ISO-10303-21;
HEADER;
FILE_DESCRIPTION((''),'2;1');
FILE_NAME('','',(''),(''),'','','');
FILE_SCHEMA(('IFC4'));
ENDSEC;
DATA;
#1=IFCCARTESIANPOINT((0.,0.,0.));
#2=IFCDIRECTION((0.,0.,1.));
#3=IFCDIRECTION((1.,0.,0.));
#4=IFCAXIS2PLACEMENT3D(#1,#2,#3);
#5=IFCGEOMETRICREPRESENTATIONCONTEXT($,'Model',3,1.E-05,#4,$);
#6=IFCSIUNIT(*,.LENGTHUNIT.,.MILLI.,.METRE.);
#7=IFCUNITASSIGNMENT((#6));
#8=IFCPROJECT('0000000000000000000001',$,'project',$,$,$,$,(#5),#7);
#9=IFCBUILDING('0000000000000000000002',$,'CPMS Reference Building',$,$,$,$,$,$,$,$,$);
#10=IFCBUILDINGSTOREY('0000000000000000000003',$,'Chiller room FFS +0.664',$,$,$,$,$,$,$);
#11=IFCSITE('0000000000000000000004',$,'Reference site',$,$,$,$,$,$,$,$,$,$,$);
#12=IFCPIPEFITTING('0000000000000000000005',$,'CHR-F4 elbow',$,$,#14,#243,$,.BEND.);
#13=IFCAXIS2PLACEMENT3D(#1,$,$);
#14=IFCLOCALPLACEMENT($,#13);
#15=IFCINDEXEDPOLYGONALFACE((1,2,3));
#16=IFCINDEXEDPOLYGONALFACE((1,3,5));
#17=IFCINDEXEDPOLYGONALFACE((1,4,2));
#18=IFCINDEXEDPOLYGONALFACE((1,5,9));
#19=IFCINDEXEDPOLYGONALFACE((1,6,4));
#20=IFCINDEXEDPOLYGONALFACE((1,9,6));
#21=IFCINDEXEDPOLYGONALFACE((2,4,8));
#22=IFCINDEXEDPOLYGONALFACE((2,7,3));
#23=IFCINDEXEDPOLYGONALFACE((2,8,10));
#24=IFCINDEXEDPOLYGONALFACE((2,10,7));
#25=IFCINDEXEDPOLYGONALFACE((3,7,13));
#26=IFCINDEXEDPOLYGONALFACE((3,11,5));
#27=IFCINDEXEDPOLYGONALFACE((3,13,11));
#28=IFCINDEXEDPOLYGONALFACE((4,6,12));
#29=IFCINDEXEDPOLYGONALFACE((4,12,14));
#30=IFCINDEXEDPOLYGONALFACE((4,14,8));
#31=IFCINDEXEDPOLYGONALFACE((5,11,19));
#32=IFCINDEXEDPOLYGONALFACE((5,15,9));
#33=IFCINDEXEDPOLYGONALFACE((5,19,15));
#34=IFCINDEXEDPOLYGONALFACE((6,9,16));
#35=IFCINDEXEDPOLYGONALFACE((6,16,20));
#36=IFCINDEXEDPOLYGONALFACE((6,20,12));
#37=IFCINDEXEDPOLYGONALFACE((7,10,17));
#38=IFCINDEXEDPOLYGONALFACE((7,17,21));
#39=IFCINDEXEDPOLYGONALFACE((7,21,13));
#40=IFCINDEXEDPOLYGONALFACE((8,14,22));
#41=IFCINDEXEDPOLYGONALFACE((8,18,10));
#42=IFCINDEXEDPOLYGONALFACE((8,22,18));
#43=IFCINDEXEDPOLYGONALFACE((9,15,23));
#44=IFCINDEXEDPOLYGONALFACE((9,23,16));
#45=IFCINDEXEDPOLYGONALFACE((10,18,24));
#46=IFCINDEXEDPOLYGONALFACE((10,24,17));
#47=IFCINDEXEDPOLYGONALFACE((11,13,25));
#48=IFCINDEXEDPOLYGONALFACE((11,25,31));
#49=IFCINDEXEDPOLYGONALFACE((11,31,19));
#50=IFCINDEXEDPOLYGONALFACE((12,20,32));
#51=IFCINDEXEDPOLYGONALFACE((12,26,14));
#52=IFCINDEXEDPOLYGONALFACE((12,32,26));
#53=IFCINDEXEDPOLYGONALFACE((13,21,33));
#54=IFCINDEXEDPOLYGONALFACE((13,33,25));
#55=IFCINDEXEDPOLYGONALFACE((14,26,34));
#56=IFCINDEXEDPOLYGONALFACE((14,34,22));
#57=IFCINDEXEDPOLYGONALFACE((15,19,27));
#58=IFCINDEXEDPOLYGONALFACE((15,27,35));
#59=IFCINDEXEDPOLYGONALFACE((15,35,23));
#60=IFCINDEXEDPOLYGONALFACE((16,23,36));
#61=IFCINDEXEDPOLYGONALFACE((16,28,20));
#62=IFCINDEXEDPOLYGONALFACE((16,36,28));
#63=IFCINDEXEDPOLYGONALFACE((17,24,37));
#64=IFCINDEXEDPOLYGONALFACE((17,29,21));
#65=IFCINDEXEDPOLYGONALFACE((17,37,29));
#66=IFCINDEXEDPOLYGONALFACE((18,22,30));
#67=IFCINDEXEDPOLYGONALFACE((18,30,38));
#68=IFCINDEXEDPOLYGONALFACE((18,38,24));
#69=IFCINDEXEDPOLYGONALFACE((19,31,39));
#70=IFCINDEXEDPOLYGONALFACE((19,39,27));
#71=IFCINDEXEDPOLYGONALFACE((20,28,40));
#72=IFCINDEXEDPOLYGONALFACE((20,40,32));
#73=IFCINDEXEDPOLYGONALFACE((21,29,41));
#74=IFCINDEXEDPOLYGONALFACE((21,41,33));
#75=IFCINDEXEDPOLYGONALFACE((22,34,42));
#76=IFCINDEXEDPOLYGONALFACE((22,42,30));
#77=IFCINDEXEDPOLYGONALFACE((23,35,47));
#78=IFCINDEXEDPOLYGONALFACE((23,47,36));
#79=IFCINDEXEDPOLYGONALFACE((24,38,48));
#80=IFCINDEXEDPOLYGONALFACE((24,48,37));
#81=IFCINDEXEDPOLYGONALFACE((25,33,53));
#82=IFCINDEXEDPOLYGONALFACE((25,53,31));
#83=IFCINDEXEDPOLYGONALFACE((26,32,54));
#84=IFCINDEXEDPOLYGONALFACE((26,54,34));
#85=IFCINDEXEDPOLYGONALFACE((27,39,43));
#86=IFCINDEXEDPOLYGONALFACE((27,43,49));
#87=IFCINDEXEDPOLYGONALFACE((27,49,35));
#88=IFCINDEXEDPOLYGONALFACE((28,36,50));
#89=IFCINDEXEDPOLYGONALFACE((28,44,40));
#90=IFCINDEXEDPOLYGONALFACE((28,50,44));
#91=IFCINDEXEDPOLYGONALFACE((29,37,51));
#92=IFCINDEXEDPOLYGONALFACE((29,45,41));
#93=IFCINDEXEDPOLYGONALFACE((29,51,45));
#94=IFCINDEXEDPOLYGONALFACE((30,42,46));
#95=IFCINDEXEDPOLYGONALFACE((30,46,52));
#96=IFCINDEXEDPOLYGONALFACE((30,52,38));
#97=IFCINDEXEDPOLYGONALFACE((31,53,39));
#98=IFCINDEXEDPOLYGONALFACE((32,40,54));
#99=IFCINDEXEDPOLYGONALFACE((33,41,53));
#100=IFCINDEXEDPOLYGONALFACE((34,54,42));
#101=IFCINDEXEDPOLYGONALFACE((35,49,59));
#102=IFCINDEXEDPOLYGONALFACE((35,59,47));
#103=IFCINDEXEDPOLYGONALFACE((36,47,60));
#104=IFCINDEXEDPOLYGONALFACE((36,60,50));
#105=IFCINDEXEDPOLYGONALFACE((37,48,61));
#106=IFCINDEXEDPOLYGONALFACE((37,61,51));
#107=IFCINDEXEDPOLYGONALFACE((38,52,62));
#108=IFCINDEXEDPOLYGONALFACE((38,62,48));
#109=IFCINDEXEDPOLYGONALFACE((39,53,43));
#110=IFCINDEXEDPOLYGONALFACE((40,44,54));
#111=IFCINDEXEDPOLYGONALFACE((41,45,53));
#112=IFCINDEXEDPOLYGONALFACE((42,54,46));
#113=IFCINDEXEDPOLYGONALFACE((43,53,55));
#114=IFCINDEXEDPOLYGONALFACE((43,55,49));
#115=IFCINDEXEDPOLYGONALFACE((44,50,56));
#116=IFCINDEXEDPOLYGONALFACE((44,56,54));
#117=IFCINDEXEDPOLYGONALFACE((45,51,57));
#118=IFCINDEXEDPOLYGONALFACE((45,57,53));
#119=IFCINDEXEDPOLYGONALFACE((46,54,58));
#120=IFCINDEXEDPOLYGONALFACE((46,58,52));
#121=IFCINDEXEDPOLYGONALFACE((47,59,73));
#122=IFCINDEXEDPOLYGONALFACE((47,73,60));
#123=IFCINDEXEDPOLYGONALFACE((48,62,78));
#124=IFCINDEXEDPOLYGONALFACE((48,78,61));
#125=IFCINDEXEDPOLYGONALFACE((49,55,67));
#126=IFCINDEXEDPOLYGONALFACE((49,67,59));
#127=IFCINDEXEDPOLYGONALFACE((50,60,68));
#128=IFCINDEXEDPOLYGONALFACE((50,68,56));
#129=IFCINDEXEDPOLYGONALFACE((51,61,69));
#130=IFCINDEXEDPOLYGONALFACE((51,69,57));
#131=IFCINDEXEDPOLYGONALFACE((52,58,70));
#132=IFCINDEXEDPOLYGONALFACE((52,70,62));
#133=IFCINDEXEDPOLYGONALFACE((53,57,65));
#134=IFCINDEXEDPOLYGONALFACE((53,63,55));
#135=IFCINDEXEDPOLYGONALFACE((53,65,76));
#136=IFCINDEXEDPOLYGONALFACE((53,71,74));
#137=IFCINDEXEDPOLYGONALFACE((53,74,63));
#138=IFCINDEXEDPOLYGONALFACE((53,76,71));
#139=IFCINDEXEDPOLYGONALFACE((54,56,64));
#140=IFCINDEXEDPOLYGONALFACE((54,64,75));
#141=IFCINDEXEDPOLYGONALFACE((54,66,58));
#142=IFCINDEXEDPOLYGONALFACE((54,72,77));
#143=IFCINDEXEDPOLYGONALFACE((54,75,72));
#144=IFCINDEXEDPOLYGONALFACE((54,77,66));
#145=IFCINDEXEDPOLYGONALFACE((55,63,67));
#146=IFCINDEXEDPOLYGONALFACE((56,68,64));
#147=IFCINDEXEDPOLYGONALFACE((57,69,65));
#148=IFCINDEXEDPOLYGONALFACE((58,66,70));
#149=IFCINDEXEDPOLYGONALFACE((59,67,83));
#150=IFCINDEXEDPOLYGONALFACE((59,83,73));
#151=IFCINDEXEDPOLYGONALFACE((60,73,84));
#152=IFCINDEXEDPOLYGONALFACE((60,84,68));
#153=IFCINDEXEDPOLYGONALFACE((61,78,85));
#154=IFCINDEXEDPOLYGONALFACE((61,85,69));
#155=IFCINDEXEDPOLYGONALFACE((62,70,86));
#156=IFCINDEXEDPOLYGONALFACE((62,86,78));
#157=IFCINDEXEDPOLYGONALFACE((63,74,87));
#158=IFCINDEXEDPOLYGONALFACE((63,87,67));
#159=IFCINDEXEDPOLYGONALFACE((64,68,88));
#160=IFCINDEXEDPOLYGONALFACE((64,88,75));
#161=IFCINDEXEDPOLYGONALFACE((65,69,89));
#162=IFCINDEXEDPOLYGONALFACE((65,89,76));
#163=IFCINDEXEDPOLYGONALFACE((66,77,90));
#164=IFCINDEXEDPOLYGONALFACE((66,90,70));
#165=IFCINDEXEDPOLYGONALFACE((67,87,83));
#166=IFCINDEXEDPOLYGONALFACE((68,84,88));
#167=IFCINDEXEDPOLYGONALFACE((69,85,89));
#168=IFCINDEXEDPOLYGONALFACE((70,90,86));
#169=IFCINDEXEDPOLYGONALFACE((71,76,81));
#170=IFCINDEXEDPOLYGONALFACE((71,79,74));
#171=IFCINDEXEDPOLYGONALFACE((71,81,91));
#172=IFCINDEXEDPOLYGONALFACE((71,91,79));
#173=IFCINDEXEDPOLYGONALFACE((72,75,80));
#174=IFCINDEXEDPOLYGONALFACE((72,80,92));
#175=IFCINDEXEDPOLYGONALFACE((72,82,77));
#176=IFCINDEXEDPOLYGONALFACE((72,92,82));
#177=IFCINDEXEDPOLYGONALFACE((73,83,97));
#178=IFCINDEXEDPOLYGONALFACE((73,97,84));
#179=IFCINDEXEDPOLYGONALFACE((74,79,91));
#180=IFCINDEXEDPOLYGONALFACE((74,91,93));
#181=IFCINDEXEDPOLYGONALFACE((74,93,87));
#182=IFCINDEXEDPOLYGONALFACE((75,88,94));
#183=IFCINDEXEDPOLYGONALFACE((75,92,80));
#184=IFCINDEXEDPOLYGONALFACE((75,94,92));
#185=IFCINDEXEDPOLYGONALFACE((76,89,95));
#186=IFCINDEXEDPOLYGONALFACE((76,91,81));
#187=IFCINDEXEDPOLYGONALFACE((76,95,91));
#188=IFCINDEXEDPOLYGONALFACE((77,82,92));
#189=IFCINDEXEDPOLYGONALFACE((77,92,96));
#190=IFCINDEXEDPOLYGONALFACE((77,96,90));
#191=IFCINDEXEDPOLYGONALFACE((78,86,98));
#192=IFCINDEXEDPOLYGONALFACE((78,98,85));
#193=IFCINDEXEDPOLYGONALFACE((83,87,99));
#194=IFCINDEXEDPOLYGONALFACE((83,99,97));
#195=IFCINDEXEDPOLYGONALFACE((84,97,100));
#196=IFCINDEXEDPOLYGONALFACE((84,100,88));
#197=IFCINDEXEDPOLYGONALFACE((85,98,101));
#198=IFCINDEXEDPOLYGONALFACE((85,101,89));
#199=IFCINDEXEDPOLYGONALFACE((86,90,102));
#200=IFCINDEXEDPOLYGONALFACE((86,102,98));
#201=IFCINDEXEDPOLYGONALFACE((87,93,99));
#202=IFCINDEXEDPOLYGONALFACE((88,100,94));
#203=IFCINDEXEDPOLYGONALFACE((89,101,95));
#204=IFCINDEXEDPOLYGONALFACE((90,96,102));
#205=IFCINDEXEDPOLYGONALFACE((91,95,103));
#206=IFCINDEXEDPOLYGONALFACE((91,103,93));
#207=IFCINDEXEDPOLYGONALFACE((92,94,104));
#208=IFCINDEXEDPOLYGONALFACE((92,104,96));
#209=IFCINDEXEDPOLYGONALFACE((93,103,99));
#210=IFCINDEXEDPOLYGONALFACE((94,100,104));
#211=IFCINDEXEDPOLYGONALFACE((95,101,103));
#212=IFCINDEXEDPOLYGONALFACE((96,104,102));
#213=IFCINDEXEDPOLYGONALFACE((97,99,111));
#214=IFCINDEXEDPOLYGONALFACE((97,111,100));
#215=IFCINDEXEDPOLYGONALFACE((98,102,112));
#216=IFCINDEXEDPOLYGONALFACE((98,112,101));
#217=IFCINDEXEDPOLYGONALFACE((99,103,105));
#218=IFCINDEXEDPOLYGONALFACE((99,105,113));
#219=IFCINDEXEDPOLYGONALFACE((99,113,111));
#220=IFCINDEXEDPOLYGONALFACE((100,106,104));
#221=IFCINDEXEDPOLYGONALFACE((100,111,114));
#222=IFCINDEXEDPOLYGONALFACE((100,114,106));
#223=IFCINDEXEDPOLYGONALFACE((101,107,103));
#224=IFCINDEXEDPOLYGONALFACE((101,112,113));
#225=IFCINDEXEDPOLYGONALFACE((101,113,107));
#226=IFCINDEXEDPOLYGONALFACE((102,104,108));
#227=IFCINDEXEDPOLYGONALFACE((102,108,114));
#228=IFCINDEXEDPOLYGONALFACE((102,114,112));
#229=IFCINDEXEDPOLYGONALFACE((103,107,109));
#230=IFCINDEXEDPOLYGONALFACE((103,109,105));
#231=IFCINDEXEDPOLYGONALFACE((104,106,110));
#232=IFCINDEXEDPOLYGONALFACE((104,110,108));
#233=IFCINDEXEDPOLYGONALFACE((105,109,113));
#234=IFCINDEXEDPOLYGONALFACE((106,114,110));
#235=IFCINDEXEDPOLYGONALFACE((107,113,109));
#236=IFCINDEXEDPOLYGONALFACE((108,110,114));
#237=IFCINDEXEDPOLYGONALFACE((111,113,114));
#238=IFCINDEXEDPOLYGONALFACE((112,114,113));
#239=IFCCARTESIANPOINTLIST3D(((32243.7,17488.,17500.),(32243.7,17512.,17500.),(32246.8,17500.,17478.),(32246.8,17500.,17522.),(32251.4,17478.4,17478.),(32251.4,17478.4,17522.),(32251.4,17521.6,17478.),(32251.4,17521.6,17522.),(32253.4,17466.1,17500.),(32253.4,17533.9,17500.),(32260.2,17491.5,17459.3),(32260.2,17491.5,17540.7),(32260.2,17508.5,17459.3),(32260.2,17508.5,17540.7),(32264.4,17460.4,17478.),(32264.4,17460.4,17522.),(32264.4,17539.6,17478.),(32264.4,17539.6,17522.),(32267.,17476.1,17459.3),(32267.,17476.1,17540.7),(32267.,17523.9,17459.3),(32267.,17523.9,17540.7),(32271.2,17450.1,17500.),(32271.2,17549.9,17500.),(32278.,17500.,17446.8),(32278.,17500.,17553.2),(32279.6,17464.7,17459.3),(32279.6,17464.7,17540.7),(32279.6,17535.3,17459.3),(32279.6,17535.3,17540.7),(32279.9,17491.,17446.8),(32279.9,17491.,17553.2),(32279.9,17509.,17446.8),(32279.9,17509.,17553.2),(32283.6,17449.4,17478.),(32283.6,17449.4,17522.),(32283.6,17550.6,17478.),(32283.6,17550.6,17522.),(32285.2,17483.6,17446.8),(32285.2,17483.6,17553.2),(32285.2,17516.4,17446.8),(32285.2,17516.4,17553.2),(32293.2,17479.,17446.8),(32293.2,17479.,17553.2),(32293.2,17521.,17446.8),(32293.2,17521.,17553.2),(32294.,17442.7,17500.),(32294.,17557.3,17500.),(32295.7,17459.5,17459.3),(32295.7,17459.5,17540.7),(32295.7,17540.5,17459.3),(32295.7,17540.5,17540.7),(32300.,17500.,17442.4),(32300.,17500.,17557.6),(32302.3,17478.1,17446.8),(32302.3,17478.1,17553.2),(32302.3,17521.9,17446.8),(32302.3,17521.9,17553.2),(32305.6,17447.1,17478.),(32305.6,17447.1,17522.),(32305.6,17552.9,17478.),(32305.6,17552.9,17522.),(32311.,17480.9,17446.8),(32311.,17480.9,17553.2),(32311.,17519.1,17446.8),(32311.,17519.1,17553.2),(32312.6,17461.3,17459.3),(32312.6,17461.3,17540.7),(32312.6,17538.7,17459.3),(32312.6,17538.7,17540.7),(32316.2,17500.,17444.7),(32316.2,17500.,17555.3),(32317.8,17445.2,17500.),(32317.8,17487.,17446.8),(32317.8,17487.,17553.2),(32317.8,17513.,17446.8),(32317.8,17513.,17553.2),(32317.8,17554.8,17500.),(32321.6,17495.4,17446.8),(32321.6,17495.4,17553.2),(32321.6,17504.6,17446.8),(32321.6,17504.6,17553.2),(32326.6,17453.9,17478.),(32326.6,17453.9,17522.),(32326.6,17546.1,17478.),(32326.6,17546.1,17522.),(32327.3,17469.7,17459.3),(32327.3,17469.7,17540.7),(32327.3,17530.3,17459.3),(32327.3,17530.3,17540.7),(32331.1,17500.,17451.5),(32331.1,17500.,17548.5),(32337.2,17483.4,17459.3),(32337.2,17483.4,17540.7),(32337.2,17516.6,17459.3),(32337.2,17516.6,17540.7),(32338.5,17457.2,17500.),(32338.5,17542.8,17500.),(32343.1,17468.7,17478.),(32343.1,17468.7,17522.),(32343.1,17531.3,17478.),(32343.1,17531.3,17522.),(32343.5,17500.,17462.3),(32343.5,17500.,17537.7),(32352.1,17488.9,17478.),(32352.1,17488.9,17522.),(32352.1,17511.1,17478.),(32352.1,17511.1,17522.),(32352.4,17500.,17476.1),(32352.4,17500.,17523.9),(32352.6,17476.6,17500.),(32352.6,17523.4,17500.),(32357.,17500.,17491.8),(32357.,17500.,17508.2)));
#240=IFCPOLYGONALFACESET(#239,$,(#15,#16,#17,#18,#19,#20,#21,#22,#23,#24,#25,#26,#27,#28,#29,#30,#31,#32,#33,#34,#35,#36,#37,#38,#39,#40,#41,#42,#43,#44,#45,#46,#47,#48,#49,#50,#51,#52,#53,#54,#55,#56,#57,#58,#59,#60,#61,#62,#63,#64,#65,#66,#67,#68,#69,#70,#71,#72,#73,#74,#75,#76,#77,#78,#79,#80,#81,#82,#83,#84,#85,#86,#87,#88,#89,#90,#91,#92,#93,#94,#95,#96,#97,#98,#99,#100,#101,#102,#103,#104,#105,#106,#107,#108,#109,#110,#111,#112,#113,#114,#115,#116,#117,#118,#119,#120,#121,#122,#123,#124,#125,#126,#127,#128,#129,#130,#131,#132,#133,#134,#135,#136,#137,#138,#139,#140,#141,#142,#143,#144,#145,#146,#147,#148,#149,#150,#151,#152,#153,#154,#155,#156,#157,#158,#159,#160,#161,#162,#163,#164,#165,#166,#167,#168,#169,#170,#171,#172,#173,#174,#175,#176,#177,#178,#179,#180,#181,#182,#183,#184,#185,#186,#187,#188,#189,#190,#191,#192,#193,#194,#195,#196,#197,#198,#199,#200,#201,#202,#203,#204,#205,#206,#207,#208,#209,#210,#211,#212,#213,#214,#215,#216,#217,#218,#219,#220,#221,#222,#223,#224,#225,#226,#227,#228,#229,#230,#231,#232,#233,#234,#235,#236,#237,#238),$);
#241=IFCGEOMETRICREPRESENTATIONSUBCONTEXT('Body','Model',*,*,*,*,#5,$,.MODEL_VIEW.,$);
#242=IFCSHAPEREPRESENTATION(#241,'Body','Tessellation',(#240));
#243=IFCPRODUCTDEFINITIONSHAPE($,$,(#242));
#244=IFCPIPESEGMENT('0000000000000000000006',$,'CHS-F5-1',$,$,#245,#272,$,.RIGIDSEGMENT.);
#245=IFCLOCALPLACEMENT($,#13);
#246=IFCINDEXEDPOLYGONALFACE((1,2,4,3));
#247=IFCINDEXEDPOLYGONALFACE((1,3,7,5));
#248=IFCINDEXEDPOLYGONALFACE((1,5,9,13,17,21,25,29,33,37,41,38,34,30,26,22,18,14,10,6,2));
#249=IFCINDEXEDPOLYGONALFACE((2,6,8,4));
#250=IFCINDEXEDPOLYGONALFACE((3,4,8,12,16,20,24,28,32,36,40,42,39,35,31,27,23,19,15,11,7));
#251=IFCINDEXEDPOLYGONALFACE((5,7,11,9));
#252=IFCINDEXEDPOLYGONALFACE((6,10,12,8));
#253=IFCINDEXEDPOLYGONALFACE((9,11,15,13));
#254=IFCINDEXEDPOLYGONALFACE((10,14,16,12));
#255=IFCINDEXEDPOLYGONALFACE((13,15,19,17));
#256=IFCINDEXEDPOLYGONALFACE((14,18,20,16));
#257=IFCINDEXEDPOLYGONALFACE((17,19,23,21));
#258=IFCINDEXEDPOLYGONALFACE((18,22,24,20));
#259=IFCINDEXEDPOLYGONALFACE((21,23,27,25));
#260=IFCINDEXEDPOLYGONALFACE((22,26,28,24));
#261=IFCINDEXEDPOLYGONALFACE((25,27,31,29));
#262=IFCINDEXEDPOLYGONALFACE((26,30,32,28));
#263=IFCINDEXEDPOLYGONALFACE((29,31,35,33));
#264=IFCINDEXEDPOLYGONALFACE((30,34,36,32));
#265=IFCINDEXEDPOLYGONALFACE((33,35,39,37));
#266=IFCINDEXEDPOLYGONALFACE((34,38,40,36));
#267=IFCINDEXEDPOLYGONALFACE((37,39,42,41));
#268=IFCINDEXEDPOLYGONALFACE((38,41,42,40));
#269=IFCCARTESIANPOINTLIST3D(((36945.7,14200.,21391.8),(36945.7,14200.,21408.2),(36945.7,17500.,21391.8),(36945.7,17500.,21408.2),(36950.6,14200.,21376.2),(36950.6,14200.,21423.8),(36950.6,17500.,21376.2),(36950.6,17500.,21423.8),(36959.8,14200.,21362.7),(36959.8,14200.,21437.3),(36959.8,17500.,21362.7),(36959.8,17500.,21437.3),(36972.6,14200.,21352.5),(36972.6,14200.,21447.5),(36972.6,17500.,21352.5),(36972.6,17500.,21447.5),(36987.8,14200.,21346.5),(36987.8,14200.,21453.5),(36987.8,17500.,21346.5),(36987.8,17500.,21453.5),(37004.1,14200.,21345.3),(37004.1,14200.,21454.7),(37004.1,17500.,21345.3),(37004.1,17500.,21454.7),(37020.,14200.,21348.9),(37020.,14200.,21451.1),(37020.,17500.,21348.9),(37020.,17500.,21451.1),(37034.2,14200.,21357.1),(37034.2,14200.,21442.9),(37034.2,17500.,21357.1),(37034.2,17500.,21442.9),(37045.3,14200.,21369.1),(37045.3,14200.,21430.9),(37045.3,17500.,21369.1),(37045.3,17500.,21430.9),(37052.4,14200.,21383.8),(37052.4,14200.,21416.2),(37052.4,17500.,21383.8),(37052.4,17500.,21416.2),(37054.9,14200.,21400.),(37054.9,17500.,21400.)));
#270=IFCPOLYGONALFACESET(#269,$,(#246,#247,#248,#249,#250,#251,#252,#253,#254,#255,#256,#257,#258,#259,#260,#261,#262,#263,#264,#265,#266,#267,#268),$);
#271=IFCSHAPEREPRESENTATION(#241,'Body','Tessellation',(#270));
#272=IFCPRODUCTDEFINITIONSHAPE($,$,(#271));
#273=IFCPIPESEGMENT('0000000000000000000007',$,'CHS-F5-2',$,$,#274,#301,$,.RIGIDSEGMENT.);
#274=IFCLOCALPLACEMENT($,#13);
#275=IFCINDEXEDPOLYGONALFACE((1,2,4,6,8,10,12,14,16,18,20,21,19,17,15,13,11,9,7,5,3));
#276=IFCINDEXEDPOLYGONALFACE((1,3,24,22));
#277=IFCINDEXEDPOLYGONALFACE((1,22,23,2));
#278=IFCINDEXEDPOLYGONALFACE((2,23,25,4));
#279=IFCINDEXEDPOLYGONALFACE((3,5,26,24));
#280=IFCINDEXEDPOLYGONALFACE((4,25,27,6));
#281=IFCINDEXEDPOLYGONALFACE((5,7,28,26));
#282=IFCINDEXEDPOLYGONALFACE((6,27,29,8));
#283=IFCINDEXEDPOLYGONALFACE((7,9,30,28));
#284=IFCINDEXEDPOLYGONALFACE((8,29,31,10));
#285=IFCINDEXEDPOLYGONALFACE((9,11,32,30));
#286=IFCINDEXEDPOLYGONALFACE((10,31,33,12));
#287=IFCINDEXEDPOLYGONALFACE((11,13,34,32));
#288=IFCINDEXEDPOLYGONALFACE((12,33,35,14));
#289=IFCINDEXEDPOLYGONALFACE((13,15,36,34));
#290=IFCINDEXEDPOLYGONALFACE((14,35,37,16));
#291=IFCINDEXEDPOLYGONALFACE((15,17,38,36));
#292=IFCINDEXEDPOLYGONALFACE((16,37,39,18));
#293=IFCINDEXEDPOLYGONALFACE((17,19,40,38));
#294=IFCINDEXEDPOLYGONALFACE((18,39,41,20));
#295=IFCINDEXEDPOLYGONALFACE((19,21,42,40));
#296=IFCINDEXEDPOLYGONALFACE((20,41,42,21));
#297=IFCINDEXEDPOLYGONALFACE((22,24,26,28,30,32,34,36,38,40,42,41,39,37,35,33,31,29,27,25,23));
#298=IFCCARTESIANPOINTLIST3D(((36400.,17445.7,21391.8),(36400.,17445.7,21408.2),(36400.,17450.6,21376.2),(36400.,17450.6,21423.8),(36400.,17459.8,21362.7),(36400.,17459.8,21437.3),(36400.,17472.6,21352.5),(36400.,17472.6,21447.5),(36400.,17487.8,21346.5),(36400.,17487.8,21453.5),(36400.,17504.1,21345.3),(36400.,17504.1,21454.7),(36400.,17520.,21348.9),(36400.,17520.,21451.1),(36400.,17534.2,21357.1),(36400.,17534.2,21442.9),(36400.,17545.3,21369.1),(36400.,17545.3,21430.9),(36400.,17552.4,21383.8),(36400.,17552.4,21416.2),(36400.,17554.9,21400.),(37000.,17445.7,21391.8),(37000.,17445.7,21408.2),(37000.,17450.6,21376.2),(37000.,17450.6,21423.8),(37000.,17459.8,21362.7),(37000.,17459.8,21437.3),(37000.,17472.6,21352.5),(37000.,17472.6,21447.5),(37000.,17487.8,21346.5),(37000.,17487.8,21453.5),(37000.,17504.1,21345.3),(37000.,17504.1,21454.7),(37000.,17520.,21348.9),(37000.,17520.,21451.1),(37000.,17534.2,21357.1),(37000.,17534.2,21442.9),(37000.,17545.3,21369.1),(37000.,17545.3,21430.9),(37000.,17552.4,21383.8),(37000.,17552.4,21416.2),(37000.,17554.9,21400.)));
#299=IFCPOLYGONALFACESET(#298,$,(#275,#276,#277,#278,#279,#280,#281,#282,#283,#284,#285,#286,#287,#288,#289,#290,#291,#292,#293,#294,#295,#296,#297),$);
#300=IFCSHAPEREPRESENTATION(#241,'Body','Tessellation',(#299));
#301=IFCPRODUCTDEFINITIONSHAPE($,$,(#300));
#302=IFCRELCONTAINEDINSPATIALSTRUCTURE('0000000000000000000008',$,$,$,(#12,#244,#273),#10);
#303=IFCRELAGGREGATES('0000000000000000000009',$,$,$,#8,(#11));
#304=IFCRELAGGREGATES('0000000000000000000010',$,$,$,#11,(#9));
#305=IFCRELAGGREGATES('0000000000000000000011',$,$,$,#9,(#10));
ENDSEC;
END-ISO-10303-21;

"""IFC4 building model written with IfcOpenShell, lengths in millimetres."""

from ifc_helpers import new_model, entity, si_unit, frame, origin_with_axes, origin_2d, place, context, subcontext, project, spatial, circle_curve, outline, extrude, element, save


model = new_model("IFC4")

# Units and contexts
model_context = context("Model", 3, precision=1e-05, world=origin_with_axes())
body_context = subcontext(model_context, "Body", "Model", "MODEL_VIEW")
ifc_project = project(units=[si_unit("LENGTHUNIT", "METRE", prefix="MILLI")], contexts=[model_context])

# Site, building, storey
site = spatial("IfcSite", under=ifc_project, Name="Reference site")
building = spatial("IfcBuilding", under=site, Name="CPMS Reference Building")
storey = spatial("IfcBuildingStorey", under=building, Name="Chiller room FFS +0.664")

# Pipe fitting
pipe_fitting_1_placement = place(None, origin_with_axes())
element("IfcPipeFitting", 1, at=pipe_fitting_1_placement, inside=storey, Name="CHR-F4 elbow", PredefinedType="BEND", context=body_context, shape_type="CSG", body=[
    entity("IfcSphere", entity("IfcAxis2Placement3D", entity("IfcCartesianPoint", [32300.0, 17500.0, 17500.0]), entity("IfcDirection", [0.0, 0.0, 1.0]), entity("IfcDirection", [1.0, 0.0, 0.0])), 57.6),
])

# Pipe segments
pipe_segment_1_placement = place(None, origin_with_axes())
element("IfcPipeSegment", 2, at=pipe_segment_1_placement, inside=storey, Name="CHS-F5-1", PredefinedType="RIGIDSEGMENT", context=body_context, shape_type="SweptSolid", body=[
    extrude(outline(circle_curve(origin_2d(), 54.9)), frame((37000.0, 14200.0, 21400.0), z_axis=(0.0, 1.0, 0.0), x_axis=(1.0, 0.0, 0.0)), (0.0, 0.0, 1.0), 3300.0),
])
pipe_segment_2_placement = place(None, origin_with_axes())
element("IfcPipeSegment", 3, at=pipe_segment_2_placement, inside=storey, Name="CHS-F5-2", PredefinedType="RIGIDSEGMENT", context=body_context, shape_type="SweptSolid", body=[
    extrude(outline(circle_curve(origin_2d(), 54.9)), frame((37000.0, 17500.0, 21400.0), z_axis=(-1.0, 0.0, 0.0), x_axis=(0.0, 1.0, 0.0)), (0.0, 0.0, 1.0), 600.0),
])

save(model, "model.ifc")
